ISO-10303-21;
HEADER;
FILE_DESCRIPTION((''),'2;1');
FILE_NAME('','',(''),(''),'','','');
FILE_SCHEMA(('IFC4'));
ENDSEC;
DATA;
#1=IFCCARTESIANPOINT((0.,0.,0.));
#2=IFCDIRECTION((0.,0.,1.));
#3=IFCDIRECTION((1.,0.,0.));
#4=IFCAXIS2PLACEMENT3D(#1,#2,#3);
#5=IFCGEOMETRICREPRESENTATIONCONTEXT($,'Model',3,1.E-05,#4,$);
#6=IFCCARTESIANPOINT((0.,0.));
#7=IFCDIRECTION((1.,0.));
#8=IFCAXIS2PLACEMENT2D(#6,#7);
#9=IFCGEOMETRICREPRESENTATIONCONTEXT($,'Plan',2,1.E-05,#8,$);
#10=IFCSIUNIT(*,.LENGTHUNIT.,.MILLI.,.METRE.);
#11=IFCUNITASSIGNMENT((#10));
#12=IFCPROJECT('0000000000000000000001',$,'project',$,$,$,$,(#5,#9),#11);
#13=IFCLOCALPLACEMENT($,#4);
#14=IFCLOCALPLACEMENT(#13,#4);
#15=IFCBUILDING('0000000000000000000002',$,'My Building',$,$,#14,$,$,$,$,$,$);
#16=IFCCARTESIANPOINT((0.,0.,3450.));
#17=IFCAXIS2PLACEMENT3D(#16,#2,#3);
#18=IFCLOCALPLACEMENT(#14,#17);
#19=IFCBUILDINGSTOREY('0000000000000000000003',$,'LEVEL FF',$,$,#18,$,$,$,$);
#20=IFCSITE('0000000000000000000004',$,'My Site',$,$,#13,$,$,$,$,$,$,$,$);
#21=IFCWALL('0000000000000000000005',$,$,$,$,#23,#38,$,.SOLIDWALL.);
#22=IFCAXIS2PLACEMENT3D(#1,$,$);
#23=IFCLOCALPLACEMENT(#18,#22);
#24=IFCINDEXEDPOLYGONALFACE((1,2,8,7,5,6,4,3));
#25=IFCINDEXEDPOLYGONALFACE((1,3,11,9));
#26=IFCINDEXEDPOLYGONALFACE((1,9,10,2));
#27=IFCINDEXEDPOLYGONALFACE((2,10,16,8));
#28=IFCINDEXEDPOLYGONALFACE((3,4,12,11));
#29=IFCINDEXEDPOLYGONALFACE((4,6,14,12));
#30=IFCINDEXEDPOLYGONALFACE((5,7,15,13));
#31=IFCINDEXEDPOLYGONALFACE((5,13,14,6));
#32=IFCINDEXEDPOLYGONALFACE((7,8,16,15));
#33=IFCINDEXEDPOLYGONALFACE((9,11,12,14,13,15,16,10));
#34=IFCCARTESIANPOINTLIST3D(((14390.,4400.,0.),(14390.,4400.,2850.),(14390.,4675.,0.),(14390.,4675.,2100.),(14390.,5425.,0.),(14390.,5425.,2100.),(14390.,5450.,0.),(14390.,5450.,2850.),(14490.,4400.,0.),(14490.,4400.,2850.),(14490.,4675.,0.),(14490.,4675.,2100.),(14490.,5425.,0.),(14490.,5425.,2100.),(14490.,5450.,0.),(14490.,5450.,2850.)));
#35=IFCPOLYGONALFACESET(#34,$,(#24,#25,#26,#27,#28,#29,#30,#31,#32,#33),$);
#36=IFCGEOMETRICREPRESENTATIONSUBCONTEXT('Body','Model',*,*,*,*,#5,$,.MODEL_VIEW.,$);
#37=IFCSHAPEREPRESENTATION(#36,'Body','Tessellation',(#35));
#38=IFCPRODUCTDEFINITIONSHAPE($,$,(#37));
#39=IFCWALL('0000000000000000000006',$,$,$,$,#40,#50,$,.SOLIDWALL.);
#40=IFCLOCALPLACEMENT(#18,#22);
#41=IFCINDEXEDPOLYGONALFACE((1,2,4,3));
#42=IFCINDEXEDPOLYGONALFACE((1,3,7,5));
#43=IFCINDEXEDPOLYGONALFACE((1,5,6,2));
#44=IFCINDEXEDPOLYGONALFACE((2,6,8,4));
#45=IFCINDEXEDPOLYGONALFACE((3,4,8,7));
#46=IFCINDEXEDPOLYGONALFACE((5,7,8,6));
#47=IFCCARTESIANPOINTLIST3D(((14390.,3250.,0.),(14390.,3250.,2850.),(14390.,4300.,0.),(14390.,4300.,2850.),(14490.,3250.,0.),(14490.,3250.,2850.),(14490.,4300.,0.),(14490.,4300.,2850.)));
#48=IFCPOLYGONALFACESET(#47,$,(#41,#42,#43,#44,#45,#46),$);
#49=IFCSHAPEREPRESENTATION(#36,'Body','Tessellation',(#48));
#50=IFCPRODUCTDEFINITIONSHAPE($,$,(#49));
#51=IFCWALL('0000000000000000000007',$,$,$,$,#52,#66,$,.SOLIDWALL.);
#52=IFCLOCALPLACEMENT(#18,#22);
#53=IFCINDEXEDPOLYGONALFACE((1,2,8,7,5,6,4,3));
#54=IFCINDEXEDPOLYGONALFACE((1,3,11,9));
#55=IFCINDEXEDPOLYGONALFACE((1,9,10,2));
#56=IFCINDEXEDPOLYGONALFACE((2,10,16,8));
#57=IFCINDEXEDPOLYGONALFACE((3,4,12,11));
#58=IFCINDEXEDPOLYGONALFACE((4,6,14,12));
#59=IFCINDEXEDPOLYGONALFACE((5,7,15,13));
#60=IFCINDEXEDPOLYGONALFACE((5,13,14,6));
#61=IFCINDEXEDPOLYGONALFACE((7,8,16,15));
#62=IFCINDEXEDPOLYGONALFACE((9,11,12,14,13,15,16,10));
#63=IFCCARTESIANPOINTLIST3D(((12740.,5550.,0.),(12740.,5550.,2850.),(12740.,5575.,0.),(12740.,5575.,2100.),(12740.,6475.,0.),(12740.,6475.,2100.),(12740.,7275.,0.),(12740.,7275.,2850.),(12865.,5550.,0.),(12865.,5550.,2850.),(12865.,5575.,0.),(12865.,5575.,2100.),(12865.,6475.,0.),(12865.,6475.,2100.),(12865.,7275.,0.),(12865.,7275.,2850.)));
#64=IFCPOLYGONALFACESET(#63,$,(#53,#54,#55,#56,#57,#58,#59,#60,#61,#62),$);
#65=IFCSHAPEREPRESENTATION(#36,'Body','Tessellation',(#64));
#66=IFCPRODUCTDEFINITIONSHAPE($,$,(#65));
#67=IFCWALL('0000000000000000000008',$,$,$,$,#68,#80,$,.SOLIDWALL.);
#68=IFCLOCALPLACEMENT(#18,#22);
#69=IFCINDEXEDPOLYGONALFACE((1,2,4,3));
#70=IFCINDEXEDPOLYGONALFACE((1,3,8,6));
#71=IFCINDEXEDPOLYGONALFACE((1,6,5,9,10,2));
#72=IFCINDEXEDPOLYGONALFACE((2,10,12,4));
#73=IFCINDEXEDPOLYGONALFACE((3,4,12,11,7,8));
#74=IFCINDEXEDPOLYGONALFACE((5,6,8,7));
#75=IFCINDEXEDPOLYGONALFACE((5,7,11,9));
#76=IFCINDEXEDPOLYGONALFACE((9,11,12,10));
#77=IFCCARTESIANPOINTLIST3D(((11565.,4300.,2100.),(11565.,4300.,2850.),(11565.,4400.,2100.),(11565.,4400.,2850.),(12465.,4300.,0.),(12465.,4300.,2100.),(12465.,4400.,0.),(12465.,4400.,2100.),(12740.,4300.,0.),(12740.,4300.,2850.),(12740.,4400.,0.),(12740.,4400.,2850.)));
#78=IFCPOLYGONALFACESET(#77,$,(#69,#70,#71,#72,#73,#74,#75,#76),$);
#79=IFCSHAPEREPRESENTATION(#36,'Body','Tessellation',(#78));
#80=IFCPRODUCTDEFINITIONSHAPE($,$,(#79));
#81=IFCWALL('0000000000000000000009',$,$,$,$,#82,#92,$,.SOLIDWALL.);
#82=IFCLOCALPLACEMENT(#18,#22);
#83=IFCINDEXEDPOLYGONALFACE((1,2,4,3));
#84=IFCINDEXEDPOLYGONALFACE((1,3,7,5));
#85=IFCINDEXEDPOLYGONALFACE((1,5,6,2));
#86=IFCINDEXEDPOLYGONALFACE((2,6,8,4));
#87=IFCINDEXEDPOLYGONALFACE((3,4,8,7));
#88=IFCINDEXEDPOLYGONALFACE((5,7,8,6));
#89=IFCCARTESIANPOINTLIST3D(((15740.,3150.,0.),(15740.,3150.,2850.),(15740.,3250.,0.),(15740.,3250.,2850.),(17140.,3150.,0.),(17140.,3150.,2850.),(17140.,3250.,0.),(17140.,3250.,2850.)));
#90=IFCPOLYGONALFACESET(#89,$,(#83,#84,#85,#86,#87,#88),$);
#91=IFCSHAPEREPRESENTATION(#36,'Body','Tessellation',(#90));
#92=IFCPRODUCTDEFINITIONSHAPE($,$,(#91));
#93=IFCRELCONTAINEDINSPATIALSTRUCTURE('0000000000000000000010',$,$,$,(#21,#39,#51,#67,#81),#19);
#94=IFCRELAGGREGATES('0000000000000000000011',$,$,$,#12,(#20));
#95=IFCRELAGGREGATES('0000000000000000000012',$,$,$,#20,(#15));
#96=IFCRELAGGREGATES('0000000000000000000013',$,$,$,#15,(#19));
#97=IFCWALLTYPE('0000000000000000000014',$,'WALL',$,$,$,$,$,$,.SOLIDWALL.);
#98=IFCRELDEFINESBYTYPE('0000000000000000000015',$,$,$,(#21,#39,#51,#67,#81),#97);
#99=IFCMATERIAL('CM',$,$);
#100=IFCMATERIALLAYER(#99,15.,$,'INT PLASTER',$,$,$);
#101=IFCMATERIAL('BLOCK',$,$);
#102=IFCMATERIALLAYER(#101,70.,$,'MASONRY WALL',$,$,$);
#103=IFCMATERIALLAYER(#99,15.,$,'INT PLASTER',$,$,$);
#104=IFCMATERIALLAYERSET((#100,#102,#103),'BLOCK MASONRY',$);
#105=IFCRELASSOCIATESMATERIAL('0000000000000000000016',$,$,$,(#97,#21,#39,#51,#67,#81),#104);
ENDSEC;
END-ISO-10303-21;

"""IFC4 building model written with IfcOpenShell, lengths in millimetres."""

from ifc_helpers import new_model, si_unit, frame, origin_with_axes, origin_2d_with_axis, place, context, subcontext, project, spatial, indexed_curve, outline, extrude, material, layer, layer_set, layer_usage, type_object, element, save


model = new_model("IFC4")

# Units and contexts
model_context = context("Model", 3, precision=1e-05, world=origin_with_axes())
plan_context = context("Plan", 2, precision=1e-05, world=origin_2d_with_axis())
body_context = subcontext(model_context, "Body", "Model", "MODEL_VIEW")
ifc_project = project(units=[si_unit("LENGTHUNIT", "METRE", prefix="MILLI")], contexts=[model_context, plan_context])

# Site, building, storey
site_placement = place(None, origin_with_axes())
site = spatial("IfcSite", under=ifc_project, at=site_placement, Name="My Site")
building_placement = place(site_placement, origin_with_axes())
building = spatial("IfcBuilding", under=site, at=building_placement, Name="My Building")
storey_placement = place(building_placement, frame((0.0, 0.0, 3450.0), z_axis=(0.0, 0.0, 1.0), x_axis=(1.0, 0.0, 0.0)))
storey = spatial("IfcBuildingStorey", under=building, at=storey_placement, Name="LEVEL FF")

# Shared definitions
ifc_material_1 = material(Name="CM")
ifc_layer_1 = layer(ifc_material_1, 15.0, Name="INT PLASTER")
ifc_material_2 = material(Name="BLOCK")
ifc_layer_2 = layer(ifc_material_2, 70.0, Name="MASONRY WALL")
ifc_layer_3 = layer(ifc_material_1, 15.0, Name="INT PLASTER")
ifc_layer_set = layer_set([ifc_layer_1, ifc_layer_2, ifc_layer_3], Name="BLOCK MASONRY")
wall_type = type_object("IfcWallType", Name="WALL", PredefinedType="SOLIDWALL", material=ifc_layer_set)

# Wall, opening
ifc_layer_usage_1 = layer_usage(ifc_layer_set, "AXIS2", "POSITIVE", 0.0)
wall_1_placement = place(storey_placement, frame((14490.0, 4400.0, 0.0), z_axis=(0.0, 0.0, 1.0), x_axis=(0.0, 1.0, 0.0)))
wall_1 = element("IfcWall", 1, at=wall_1_placement, inside=storey, type_object=wall_type, material=ifc_layer_usage_1, PredefinedType="SOLIDWALL", context=body_context, shape_type="SweptSolid", body=[
    extrude(outline(indexed_curve([(0.0, 0.0), (0.0, 100.0), (1050.0, 100.0), (1050.0, 0.0), (0.0, 0.0)], self_intersect=False)), origin_with_axes(), (0.0, 0.0, 1.0), 2850.0),
])
opening_1_placement = place(wall_1_placement, frame((275.0, 0.0, 0.0), z_axis=(0.0, 0.0, 1.0), x_axis=(1.0, 0.0, 0.0)))
element("IfcOpeningElement", 2, at=opening_1_placement, cuts=wall_1, PredefinedType="OPENING", context=body_context, shape_type="SweptSolid", body=[
    extrude(outline(indexed_curve([(0.0, 0.0), (0.0, 400.0), (750.0, 400.0), (750.0, 0.0), (0.0, 0.0)], self_intersect=False)), frame((0.0, -100.0, 0.0), z_axis=(0.0, 0.0, 1.0), x_axis=(1.0, 0.0, 0.0)), (0.0, 0.0, 1.0), 2100.0),
])

# Wall
ifc_layer_usage_2 = layer_usage(ifc_layer_set, "AXIS2", "POSITIVE", 0.0)
wall_2_placement = place(storey_placement, frame((14490.0, 3250.0, 0.0), z_axis=(0.0, 0.0, 1.0), x_axis=(0.0, 1.0, 0.0)))
element("IfcWall", 3, at=wall_2_placement, inside=storey, type_object=wall_type, material=ifc_layer_usage_2, PredefinedType="SOLIDWALL", context=body_context, shape_type="SweptSolid", body=[
    extrude(outline(indexed_curve([(0.0, 0.0), (0.0, 100.0), (1050.0, 100.0), (1050.0, 0.0), (0.0, 0.0)], self_intersect=False)), origin_with_axes(), (0.0, 0.0, 1.0), 2850.0),
])

# Walls, openings
ifc_layer_usage_3 = layer_usage(ifc_layer_set, "AXIS2", "POSITIVE", 0.0)
wall_3_placement = place(storey_placement, frame((12865.0, 5550.0, 0.0), z_axis=(0.0, 0.0, 1.0), x_axis=(0.0, 1.0, 0.0)))
wall_3 = element("IfcWall", 4, at=wall_3_placement, inside=storey, type_object=wall_type, material=ifc_layer_usage_3, PredefinedType="SOLIDWALL", context=body_context, shape_type="SweptSolid", body=[
    extrude(outline(indexed_curve([(0.0, 0.0), (0.0, 125.0), (1725.0, 125.0), (1725.0, 0.0), (0.0, 0.0)], self_intersect=False)), origin_with_axes(), (0.0, 0.0, 1.0), 2850.0),
])
opening_2_placement = place(wall_3_placement, frame((925.0, 125.0, 0.0), z_axis=(0.0, 0.0, 1.0), x_axis=(-1.0, 0.0, 0.0)))
element("IfcOpeningElement", 5, at=opening_2_placement, cuts=wall_3, PredefinedType="OPENING", context=body_context, shape_type="SweptSolid", body=[
    extrude(outline(indexed_curve([(0.0, 0.0), (0.0, 400.0), (900.0, 400.0), (900.0, 0.0), (0.0, 0.0)], self_intersect=False)), frame((0.0, -100.0, 0.0), z_axis=(0.0, 0.0, 1.0), x_axis=(1.0, 0.0, 0.0)), (0.0, 0.0, 1.0), 2100.0),
])
ifc_layer_usage_4 = layer_usage(ifc_layer_set, "AXIS2", "POSITIVE", 0.0)
wall_4_placement = place(storey_placement, frame((11565.0, 4400.0, 0.0), z_axis=(0.0, 0.0, 1.0), x_axis=(0.0, -1.0, 0.0)))
wall_4 = element("IfcWall", 6, at=wall_4_placement, inside=storey, type_object=wall_type, material=ifc_layer_usage_4, PredefinedType="SOLIDWALL", context=body_context, shape_type="SweptSolid", body=[
    extrude(outline(indexed_curve([(0.0, 0.0), (0.0, 1175.0), (100.0, 1175.0), (100.0, 0.0), (0.0, 0.0)], self_intersect=False)), origin_with_axes(), (0.0, 0.0, 1.0), 2850.0),
])
opening_3_placement = place(wall_4_placement, frame((0.0, 900.0, 0.0), z_axis=(0.0, 0.0, 1.0), x_axis=(0.0, -1.0, 0.0)))
element("IfcOpeningElement", 7, at=opening_3_placement, cuts=wall_4, PredefinedType="OPENING", context=body_context, shape_type="SweptSolid", body=[
    extrude(outline(indexed_curve([(0.0, 0.0), (0.0, 400.0), (900.0, 400.0), (900.0, 0.0), (0.0, 0.0)], self_intersect=False)), frame((0.0, -100.0, 0.0), z_axis=(0.0, 0.0, 1.0), x_axis=(1.0, 0.0, 0.0)), (0.0, 0.0, 1.0), 2100.0),
])

# Wall
ifc_layer_usage_5 = layer_usage(ifc_layer_set, "AXIS2", "POSITIVE", 0.0)
wall_5_placement = place(storey_placement, frame((15740.0, 3250.0, 0.0), z_axis=(0.0, 0.0, 1.0), x_axis=(0.0, -1.0, 0.0)))
element("IfcWall", 8, at=wall_5_placement, inside=storey, type_object=wall_type, material=ifc_layer_usage_5, PredefinedType="SOLIDWALL", context=body_context, shape_type="SweptSolid", body=[
    extrude(outline(indexed_curve([(0.0, 0.0), (0.0, 1400.0), (100.0, 1400.0), (100.0, 0.0), (0.0, 0.0)], self_intersect=False)), origin_with_axes(), (0.0, 0.0, 1.0), 2850.0),
])

save(model, "model.ifc")
